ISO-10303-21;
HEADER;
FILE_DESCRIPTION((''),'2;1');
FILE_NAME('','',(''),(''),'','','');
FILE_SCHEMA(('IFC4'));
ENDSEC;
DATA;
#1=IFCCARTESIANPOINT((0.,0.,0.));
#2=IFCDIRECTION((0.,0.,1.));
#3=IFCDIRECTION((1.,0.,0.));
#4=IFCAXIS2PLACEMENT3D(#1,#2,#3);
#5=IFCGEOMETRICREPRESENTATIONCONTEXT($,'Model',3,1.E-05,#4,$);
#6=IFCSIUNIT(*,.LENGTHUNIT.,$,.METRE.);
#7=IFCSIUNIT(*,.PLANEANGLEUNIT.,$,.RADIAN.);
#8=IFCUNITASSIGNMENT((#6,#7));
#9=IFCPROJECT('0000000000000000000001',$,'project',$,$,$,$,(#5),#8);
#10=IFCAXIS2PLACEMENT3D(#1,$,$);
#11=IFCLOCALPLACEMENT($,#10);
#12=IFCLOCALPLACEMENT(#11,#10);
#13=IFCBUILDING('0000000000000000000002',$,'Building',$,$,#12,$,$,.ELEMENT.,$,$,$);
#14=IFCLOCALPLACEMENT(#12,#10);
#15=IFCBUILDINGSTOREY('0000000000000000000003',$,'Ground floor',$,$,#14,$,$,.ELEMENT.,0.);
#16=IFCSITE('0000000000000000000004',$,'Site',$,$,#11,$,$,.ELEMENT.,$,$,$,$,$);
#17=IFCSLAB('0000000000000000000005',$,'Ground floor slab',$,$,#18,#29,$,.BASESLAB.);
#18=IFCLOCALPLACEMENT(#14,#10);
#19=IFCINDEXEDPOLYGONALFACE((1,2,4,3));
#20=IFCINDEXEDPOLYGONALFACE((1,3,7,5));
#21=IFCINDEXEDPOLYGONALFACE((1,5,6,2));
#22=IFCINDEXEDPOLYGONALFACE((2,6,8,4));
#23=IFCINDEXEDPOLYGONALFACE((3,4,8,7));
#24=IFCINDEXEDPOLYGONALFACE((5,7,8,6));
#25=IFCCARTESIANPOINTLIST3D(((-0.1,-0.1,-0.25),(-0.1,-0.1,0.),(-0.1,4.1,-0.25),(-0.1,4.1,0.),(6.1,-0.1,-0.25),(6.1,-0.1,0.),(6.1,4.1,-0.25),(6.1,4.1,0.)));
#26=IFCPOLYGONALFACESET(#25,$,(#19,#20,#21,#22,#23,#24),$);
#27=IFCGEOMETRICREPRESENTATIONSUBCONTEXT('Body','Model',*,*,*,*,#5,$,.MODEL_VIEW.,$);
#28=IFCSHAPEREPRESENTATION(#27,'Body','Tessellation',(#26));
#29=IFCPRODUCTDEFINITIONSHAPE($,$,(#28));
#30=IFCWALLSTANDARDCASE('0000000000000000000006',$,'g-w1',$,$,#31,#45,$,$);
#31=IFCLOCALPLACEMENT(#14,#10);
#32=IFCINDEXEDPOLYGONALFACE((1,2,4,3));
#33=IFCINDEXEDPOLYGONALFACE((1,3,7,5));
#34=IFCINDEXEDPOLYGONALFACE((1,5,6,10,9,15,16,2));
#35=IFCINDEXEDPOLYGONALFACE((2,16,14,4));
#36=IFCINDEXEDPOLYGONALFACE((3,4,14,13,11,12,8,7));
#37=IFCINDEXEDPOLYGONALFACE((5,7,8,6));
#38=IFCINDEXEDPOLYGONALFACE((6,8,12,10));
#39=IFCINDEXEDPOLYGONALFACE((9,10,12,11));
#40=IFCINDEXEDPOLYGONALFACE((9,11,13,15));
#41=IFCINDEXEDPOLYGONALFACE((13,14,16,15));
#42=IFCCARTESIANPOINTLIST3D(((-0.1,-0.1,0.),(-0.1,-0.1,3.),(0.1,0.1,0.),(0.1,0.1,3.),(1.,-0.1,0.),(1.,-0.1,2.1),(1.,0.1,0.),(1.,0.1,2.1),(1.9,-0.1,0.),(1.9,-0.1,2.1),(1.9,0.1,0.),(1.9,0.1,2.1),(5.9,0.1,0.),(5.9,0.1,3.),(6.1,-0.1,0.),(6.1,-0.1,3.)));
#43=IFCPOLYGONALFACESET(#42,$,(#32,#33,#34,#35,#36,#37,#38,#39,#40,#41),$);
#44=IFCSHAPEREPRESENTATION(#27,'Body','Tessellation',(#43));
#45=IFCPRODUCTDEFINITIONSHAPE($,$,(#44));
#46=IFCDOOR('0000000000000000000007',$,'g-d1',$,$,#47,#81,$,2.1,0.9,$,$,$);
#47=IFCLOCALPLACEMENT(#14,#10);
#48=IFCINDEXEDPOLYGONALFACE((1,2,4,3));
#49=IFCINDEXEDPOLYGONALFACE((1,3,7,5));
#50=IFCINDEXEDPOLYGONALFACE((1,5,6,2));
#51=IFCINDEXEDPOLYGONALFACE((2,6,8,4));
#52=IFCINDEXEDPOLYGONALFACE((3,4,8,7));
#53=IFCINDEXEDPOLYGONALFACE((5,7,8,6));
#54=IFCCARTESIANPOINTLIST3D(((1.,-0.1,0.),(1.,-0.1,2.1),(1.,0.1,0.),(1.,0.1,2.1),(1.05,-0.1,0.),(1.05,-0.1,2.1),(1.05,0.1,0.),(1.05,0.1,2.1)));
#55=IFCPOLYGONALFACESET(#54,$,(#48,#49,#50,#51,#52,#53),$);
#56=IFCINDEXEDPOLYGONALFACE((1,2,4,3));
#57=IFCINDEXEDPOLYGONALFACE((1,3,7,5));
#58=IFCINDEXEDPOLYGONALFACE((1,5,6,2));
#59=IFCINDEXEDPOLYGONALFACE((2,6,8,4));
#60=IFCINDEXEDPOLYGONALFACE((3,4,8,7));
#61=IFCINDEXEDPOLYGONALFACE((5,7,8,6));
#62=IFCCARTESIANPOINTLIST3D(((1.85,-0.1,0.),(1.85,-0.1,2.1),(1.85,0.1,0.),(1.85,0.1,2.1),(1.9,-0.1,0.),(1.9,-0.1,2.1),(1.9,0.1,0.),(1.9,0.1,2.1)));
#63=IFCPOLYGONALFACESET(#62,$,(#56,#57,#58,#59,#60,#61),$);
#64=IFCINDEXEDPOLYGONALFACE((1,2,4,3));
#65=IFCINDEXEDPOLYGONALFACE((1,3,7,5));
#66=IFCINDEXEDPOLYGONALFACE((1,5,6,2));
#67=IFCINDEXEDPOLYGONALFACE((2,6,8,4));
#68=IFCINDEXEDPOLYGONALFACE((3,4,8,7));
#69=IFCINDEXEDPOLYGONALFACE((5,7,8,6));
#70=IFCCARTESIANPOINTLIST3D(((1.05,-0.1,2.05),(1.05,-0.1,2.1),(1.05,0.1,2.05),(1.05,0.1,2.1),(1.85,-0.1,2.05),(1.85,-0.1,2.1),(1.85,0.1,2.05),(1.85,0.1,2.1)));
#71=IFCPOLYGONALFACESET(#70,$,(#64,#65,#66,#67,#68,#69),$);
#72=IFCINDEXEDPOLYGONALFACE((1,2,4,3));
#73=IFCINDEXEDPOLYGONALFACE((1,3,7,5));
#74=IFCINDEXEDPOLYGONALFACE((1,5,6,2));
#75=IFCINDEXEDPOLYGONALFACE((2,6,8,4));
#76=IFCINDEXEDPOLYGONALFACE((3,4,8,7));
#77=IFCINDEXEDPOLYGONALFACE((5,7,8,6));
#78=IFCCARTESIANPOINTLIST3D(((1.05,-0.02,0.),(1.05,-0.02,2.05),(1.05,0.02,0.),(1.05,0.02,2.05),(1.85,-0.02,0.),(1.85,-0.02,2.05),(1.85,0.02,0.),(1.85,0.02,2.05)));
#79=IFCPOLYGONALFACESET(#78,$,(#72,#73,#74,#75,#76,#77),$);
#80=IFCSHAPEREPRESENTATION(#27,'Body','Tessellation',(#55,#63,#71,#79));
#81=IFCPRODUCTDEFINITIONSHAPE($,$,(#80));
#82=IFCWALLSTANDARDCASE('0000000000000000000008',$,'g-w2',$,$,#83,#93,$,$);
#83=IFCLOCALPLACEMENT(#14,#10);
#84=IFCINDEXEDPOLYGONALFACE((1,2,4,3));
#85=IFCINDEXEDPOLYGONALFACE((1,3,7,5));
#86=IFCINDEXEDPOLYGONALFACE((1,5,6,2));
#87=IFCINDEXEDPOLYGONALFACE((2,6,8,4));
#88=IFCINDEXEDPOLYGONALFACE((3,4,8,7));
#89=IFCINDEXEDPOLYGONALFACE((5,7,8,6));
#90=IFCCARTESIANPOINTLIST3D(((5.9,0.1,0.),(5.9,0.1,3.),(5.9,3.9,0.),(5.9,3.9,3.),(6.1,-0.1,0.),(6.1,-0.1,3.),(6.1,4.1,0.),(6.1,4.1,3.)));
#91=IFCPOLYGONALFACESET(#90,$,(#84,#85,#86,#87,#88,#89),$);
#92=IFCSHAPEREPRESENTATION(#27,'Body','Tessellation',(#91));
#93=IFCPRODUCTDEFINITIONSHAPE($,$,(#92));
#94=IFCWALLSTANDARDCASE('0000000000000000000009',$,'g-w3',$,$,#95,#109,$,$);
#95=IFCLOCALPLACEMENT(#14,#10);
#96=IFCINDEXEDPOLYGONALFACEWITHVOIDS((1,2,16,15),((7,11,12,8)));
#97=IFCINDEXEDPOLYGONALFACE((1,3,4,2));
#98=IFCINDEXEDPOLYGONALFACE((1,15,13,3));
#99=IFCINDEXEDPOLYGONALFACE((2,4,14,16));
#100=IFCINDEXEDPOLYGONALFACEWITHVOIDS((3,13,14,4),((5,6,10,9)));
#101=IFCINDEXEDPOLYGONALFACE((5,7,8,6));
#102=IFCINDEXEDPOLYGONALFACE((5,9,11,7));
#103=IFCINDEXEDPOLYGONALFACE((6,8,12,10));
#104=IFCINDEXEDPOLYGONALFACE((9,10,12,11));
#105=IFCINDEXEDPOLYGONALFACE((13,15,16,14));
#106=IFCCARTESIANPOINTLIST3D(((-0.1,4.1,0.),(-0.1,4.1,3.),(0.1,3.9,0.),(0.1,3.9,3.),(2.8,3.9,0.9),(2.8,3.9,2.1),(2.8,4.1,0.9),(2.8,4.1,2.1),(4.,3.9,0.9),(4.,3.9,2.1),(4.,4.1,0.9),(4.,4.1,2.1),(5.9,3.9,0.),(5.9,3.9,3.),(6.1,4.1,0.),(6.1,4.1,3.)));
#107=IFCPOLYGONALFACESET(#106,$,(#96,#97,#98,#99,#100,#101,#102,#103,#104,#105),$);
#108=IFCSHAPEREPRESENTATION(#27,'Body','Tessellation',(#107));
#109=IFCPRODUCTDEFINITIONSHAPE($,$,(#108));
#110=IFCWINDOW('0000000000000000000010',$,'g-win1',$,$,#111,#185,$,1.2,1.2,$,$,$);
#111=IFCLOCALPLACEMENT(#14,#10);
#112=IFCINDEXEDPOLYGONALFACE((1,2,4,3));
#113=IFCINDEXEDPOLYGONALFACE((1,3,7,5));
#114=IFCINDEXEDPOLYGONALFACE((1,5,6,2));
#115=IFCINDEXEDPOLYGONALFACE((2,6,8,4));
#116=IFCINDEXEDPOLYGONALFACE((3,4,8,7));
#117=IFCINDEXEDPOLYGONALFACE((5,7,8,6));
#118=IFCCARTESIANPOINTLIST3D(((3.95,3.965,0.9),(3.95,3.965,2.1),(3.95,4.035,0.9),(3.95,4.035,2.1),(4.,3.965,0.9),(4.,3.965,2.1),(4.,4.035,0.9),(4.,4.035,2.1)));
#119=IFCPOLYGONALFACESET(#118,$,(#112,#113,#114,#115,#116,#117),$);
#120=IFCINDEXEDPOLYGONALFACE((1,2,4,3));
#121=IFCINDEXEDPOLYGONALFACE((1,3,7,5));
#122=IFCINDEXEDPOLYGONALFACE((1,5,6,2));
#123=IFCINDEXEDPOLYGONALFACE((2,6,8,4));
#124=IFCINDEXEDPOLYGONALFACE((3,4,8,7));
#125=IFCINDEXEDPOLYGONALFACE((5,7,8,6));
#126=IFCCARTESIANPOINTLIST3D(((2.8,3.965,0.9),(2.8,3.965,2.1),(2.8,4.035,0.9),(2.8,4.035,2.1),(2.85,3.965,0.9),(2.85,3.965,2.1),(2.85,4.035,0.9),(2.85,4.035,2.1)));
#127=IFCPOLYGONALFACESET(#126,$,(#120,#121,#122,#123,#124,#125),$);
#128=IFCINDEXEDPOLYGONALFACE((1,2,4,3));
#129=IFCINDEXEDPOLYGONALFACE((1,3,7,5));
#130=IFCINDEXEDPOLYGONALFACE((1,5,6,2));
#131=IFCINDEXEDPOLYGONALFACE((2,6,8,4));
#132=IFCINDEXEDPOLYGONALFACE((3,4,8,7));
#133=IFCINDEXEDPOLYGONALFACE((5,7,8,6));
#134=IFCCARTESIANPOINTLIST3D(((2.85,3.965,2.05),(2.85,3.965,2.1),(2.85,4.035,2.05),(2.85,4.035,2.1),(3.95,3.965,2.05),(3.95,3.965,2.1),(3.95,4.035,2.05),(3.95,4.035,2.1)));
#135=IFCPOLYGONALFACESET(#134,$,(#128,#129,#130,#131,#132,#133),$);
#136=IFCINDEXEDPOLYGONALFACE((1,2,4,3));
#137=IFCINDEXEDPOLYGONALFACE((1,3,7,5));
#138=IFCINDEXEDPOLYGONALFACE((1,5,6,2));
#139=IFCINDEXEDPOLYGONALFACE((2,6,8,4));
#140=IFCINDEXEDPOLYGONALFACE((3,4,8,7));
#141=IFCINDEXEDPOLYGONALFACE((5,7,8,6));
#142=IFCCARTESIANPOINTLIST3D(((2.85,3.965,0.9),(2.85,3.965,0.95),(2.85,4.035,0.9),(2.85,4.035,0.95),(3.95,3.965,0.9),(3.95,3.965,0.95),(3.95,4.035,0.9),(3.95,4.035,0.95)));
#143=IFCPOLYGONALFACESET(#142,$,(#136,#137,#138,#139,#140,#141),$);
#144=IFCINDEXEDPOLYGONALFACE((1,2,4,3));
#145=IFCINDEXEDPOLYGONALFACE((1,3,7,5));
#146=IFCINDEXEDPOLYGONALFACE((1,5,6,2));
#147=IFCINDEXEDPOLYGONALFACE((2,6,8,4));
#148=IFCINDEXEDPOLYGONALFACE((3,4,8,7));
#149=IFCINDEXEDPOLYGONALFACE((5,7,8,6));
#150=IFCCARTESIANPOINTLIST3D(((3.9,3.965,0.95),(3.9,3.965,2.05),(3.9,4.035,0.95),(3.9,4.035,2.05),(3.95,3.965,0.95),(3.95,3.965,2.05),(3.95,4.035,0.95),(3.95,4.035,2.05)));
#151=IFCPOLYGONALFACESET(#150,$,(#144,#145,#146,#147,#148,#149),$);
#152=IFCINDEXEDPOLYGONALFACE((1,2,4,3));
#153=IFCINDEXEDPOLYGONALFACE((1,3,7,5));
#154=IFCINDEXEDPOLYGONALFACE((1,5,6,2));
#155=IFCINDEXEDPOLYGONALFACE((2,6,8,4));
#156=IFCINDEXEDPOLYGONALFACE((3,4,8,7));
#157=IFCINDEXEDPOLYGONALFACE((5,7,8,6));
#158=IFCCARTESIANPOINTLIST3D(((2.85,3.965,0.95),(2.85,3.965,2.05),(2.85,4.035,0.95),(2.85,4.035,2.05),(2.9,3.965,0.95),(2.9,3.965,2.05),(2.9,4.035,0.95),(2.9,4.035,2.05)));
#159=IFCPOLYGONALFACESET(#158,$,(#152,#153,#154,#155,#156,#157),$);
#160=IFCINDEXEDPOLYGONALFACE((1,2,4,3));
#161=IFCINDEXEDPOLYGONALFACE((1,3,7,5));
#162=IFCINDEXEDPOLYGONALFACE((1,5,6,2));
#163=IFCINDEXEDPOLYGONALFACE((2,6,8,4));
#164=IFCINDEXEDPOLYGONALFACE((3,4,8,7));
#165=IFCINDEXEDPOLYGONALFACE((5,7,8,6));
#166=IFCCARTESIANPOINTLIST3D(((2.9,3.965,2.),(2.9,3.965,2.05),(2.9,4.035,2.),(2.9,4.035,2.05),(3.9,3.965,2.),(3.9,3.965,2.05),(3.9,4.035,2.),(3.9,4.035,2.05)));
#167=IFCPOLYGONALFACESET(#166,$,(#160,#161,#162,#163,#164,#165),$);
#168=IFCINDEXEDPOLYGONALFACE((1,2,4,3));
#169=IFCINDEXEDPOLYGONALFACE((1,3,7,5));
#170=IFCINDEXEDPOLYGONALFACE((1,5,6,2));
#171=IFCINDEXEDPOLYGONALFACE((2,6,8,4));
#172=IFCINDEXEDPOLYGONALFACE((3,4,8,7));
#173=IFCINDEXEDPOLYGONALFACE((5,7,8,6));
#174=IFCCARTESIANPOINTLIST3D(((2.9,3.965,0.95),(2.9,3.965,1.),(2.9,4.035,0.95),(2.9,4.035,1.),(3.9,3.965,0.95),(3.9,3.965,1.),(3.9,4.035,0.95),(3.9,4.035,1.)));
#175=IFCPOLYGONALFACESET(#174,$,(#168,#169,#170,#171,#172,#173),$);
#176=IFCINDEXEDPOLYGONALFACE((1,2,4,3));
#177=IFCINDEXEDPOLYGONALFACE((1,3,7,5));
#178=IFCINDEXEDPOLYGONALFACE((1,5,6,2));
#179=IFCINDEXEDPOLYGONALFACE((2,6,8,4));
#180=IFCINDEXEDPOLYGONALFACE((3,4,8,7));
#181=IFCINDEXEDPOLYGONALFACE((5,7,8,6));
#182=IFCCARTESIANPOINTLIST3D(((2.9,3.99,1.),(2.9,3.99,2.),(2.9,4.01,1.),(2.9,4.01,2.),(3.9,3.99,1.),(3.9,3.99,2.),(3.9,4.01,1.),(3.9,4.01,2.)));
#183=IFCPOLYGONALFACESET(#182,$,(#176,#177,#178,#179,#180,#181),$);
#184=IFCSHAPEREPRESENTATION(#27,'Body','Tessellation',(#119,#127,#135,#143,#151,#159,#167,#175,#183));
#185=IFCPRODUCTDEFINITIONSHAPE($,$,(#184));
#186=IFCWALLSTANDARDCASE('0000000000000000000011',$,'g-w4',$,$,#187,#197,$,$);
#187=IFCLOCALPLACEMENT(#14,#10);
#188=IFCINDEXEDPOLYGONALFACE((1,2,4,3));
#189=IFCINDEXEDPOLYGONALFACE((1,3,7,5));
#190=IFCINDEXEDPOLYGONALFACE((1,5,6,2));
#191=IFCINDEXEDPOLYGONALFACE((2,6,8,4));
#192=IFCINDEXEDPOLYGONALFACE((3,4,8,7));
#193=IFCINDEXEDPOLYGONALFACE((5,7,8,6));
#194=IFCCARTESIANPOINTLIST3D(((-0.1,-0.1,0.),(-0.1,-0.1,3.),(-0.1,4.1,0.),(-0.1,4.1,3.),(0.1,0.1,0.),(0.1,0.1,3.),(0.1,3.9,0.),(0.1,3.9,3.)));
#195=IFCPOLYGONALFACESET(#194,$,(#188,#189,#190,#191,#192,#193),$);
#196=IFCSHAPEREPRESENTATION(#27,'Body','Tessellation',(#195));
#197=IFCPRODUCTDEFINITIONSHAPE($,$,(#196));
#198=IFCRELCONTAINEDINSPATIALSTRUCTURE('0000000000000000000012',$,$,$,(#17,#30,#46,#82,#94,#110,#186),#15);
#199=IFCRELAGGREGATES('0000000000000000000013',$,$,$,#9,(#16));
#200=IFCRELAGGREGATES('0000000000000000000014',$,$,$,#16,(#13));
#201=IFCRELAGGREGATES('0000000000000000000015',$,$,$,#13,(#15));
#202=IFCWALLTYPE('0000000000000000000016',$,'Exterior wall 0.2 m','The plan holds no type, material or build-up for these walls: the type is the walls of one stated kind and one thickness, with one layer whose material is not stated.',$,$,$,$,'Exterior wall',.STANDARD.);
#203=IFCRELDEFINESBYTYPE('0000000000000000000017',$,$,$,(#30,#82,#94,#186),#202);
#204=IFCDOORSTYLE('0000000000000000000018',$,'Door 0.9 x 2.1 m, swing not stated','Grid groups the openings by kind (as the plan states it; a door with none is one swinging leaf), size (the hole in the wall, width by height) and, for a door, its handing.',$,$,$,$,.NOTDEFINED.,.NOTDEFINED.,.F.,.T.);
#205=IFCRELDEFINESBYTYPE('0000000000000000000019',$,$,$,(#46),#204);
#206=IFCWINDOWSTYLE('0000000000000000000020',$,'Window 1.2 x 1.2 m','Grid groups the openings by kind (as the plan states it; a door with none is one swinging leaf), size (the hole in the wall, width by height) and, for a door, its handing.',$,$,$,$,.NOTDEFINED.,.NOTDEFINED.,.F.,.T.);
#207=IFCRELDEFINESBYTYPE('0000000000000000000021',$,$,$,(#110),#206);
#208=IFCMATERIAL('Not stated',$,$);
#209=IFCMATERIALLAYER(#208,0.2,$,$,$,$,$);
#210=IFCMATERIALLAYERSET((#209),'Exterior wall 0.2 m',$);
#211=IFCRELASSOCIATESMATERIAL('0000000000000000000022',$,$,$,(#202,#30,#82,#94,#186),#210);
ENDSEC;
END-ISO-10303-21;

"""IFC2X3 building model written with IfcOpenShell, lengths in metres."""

from ifc_helpers import new_model, si_unit, frame, frame_2d, origin, origin_with_axes, place, context, subcontext, project, spatial, polyline, rectangle, outline, extrude, material, layer, layer_set, layer_usage, type_object, element, fill, save


model = new_model("IFC2X3")

# Units and contexts
model_context = context("Model", 3, precision=1e-05, world=origin_with_axes())
body_context = subcontext(model_context, "Body", "Model", "MODEL_VIEW")
ifc_project = project(units=[si_unit("LENGTHUNIT", "METRE"), si_unit("PLANEANGLEUNIT", "RADIAN")], contexts=[model_context])

# Site, building, storey
site_placement = place(None, origin())
site = spatial("IfcSite", under=ifc_project, at=site_placement, Name="Site", CompositionType="ELEMENT")
building_placement = place(site_placement, origin())
building = spatial("IfcBuilding", under=site, at=building_placement, Name="Building", CompositionType="ELEMENT")
storey_placement = place(building_placement, origin())
storey = spatial("IfcBuildingStorey", under=building, at=storey_placement, Name="Ground floor", CompositionType="ELEMENT", Elevation=0.0)

# Slab
slab_placement = place(storey_placement, frame((0.0, 0.0, -0.25)))
element("IfcSlab", 1, at=slab_placement, inside=storey, Name="Ground floor slab", PredefinedType="BASESLAB", context=body_context, shape_type="SweptSolid", body=[
    extrude(outline(polyline([(-0.1, -0.1), (6.1, -0.1), (6.1, 4.1), (-0.1, 4.1), (-0.1, -0.1)])), origin(), (0.0, 0.0, 1.0), 0.25),
])

# Wall, opening, door
ifc_material = material(Name="Not stated")
ifc_layer = layer(ifc_material, 0.2)
ifc_layer_set = layer_set([ifc_layer], Name="Exterior wall 0.2 m")
ifc_layer_usage = layer_usage(ifc_layer_set, "AXIS2", "POSITIVE", -0.1)
wall_type = type_object("IfcWallType", Name="Exterior wall 0.2 m", Description="The plan holds no type, material or build-up for these walls: the type is the walls of one stated kind and one thickness, with one layer whose material is not stated.", ElementType="Exterior wall", PredefinedType="STANDARD", material=ifc_layer_set)
wall_1_placement = place(storey_placement, origin_with_axes())
wall_1 = element("IfcWallStandardCase", 2, at=wall_1_placement, inside=storey, type_object=wall_type, material=ifc_layer_usage, Name="g-w1", context=body_context, shape_type="SweptSolid", body=[
    extrude(outline(polyline([(-0.1, -0.1), (6.1, -0.1), (5.9, 0.1), (0.1, 0.1), (-0.1, -0.1)])), origin(), (0.0, 0.0, 1.0), 3.0),
])
opening_1_placement = place(wall_1_placement, frame((1.0, 0.0, 0.0)))
opening_1 = element("IfcOpeningElement", 3, at=opening_1_placement, cuts=wall_1, context=body_context, shape_type="SweptSolid", body=[
    extrude(rectangle(XDim=0.9, YDim=0.22, at=frame_2d((0.45, 0.0), x_axis=(1.0, 0.0))), origin(), (0.0, 0.0, 1.0), 2.1),
])
door_style = type_object("IfcDoorStyle", Name="Door 0.9 x 2.1 m, swing not stated", Description="Grid groups the openings by kind (as the plan states it; a door with none is one swinging leaf), size (the hole in the wall, width by height) and, for a door, its handing.", ConstructionType="NOTDEFINED", OperationType="NOTDEFINED", ParameterTakesPrecedence=False, Sizeable=True)
door_placement = place(opening_1_placement, origin())
door = element("IfcDoor", 4, at=door_placement, inside=storey, type_object=door_style, Name="g-d1", OverallHeight=2.1, OverallWidth=0.9, context=body_context, shape_type="SweptSolid", body=[
    extrude(rectangle(XDim=0.05, YDim=0.2, at=frame_2d((0.025, 0.0), x_axis=(1.0, 0.0))), origin(), (0.0, 0.0, 1.0), 2.1),
    extrude(rectangle(XDim=0.05, YDim=0.2, at=frame_2d((0.875, 0.0), x_axis=(1.0, 0.0))), origin(), (0.0, 0.0, 1.0), 2.1),
    extrude(rectangle(XDim=0.8, YDim=0.2, at=frame_2d((0.45, 0.0), x_axis=(1.0, 0.0))), frame((0.0, 0.0, 2.05)), (0.0, 0.0, 1.0), 0.05),
    extrude(rectangle(XDim=0.8, YDim=0.04, at=frame_2d((0.45, 0.0), x_axis=(1.0, 0.0))), origin(), (0.0, 0.0, 1.0), 2.05),
])
fill(opening_1, door)

# Wall
wall_2_placement = place(storey_placement, frame((6.0, 0.0, 0.0), z_axis=(0.0, 0.0, 1.0), x_axis=(0.0, 1.0, 0.0)))
element("IfcWallStandardCase", 5, at=wall_2_placement, inside=storey, type_object=wall_type, material=ifc_layer_usage, Name="g-w2", context=body_context, shape_type="SweptSolid", body=[
    extrude(outline(polyline([(-0.1, -0.1), (4.1, -0.1), (3.9, 0.1), (0.1, 0.1), (-0.1, -0.1)])), origin(), (0.0, 0.0, 1.0), 3.0),
])

# Wall, opening, window
wall_3_placement = place(storey_placement, frame((6.0, 4.0, 0.0), z_axis=(0.0, 0.0, 1.0), x_axis=(-1.0, 0.0, 0.0)))
wall_3 = element("IfcWallStandardCase", 6, at=wall_3_placement, inside=storey, type_object=wall_type, material=ifc_layer_usage, Name="g-w3", context=body_context, shape_type="SweptSolid", body=[
    extrude(outline(polyline([(-0.1, -0.1), (6.1, -0.1), (5.9, 0.1), (0.1, 0.1), (-0.1, -0.1)])), origin(), (0.0, 0.0, 1.0), 3.0),
])
opening_2_placement = place(wall_3_placement, frame((2.0, 0.0, 0.9)))
opening_2 = element("IfcOpeningElement", 7, at=opening_2_placement, cuts=wall_3, context=body_context, shape_type="SweptSolid", body=[
    extrude(rectangle(XDim=1.2, YDim=0.22, at=frame_2d((0.6, 0.0), x_axis=(1.0, 0.0))), origin(), (0.0, 0.0, 1.0), 1.2),
])
window_style = type_object("IfcWindowStyle", Name="Window 1.2 x 1.2 m", Description="Grid groups the openings by kind (as the plan states it; a door with none is one swinging leaf), size (the hole in the wall, width by height) and, for a door, its handing.", ConstructionType="NOTDEFINED", OperationType="NOTDEFINED", ParameterTakesPrecedence=False, Sizeable=True)
window_placement = place(opening_2_placement, origin())
window = element("IfcWindow", 8, at=window_placement, inside=storey, type_object=window_style, Name="g-win1", OverallHeight=1.2, OverallWidth=1.2, context=body_context, shape_type="SweptSolid", body=[
    extrude(rectangle(XDim=0.05, YDim=0.07, at=frame_2d((0.025, 0.0), x_axis=(1.0, 0.0))), origin(), (0.0, 0.0, 1.0), 1.2),
    extrude(rectangle(XDim=0.05, YDim=0.07, at=frame_2d((1.175, 0.0), x_axis=(1.0, 0.0))), origin(), (0.0, 0.0, 1.0), 1.2),
    extrude(rectangle(XDim=1.1, YDim=0.07, at=frame_2d((0.6, 0.0), x_axis=(1.0, 0.0))), frame((0.0, 0.0, 1.15)), (0.0, 0.0, 1.0), 0.05),
    extrude(rectangle(XDim=1.1, YDim=0.07, at=frame_2d((0.6, 0.0), x_axis=(1.0, 0.0))), origin(), (0.0, 0.0, 1.0), 0.05),
    extrude(rectangle(XDim=0.05, YDim=0.07, at=frame_2d((0.075, 0.0), x_axis=(1.0, 0.0))), frame((0.0, 0.0, 0.05)), (0.0, 0.0, 1.0), 1.1),
    extrude(rectangle(XDim=0.05, YDim=0.07, at=frame_2d((1.125, 0.0), x_axis=(1.0, 0.0))), frame((0.0, 0.0, 0.05)), (0.0, 0.0, 1.0), 1.1),
    extrude(rectangle(XDim=1.0, YDim=0.07, at=frame_2d((0.6, 0.0), x_axis=(1.0, 0.0))), frame((0.0, 0.0, 1.1)), (0.0, 0.0, 1.0), 0.05),
    extrude(rectangle(XDim=1.0, YDim=0.07, at=frame_2d((0.6, 0.0), x_axis=(1.0, 0.0))), frame((0.0, 0.0, 0.05)), (0.0, 0.0, 1.0), 0.05),
    extrude(rectangle(XDim=1.0, YDim=0.02, at=frame_2d((0.6, 0.0), x_axis=(1.0, 0.0))), frame((0.0, 0.0, 0.1)), (0.0, 0.0, 1.0), 1.0),
])
fill(opening_2, window)

# Wall
wall_4_placement = place(storey_placement, frame((0.0, 4.0, 0.0), z_axis=(0.0, 0.0, 1.0), x_axis=(0.0, -1.0, 0.0)))
element("IfcWallStandardCase", 9, at=wall_4_placement, inside=storey, type_object=wall_type, material=ifc_layer_usage, Name="g-w4", context=body_context, shape_type="SweptSolid", body=[
    extrude(outline(polyline([(-0.1, -0.1), (4.1, -0.1), (3.9, 0.1), (0.1, 0.1), (-0.1, -0.1)])), origin(), (0.0, 0.0, 1.0), 3.0),
])

save(model, "model.ifc")
